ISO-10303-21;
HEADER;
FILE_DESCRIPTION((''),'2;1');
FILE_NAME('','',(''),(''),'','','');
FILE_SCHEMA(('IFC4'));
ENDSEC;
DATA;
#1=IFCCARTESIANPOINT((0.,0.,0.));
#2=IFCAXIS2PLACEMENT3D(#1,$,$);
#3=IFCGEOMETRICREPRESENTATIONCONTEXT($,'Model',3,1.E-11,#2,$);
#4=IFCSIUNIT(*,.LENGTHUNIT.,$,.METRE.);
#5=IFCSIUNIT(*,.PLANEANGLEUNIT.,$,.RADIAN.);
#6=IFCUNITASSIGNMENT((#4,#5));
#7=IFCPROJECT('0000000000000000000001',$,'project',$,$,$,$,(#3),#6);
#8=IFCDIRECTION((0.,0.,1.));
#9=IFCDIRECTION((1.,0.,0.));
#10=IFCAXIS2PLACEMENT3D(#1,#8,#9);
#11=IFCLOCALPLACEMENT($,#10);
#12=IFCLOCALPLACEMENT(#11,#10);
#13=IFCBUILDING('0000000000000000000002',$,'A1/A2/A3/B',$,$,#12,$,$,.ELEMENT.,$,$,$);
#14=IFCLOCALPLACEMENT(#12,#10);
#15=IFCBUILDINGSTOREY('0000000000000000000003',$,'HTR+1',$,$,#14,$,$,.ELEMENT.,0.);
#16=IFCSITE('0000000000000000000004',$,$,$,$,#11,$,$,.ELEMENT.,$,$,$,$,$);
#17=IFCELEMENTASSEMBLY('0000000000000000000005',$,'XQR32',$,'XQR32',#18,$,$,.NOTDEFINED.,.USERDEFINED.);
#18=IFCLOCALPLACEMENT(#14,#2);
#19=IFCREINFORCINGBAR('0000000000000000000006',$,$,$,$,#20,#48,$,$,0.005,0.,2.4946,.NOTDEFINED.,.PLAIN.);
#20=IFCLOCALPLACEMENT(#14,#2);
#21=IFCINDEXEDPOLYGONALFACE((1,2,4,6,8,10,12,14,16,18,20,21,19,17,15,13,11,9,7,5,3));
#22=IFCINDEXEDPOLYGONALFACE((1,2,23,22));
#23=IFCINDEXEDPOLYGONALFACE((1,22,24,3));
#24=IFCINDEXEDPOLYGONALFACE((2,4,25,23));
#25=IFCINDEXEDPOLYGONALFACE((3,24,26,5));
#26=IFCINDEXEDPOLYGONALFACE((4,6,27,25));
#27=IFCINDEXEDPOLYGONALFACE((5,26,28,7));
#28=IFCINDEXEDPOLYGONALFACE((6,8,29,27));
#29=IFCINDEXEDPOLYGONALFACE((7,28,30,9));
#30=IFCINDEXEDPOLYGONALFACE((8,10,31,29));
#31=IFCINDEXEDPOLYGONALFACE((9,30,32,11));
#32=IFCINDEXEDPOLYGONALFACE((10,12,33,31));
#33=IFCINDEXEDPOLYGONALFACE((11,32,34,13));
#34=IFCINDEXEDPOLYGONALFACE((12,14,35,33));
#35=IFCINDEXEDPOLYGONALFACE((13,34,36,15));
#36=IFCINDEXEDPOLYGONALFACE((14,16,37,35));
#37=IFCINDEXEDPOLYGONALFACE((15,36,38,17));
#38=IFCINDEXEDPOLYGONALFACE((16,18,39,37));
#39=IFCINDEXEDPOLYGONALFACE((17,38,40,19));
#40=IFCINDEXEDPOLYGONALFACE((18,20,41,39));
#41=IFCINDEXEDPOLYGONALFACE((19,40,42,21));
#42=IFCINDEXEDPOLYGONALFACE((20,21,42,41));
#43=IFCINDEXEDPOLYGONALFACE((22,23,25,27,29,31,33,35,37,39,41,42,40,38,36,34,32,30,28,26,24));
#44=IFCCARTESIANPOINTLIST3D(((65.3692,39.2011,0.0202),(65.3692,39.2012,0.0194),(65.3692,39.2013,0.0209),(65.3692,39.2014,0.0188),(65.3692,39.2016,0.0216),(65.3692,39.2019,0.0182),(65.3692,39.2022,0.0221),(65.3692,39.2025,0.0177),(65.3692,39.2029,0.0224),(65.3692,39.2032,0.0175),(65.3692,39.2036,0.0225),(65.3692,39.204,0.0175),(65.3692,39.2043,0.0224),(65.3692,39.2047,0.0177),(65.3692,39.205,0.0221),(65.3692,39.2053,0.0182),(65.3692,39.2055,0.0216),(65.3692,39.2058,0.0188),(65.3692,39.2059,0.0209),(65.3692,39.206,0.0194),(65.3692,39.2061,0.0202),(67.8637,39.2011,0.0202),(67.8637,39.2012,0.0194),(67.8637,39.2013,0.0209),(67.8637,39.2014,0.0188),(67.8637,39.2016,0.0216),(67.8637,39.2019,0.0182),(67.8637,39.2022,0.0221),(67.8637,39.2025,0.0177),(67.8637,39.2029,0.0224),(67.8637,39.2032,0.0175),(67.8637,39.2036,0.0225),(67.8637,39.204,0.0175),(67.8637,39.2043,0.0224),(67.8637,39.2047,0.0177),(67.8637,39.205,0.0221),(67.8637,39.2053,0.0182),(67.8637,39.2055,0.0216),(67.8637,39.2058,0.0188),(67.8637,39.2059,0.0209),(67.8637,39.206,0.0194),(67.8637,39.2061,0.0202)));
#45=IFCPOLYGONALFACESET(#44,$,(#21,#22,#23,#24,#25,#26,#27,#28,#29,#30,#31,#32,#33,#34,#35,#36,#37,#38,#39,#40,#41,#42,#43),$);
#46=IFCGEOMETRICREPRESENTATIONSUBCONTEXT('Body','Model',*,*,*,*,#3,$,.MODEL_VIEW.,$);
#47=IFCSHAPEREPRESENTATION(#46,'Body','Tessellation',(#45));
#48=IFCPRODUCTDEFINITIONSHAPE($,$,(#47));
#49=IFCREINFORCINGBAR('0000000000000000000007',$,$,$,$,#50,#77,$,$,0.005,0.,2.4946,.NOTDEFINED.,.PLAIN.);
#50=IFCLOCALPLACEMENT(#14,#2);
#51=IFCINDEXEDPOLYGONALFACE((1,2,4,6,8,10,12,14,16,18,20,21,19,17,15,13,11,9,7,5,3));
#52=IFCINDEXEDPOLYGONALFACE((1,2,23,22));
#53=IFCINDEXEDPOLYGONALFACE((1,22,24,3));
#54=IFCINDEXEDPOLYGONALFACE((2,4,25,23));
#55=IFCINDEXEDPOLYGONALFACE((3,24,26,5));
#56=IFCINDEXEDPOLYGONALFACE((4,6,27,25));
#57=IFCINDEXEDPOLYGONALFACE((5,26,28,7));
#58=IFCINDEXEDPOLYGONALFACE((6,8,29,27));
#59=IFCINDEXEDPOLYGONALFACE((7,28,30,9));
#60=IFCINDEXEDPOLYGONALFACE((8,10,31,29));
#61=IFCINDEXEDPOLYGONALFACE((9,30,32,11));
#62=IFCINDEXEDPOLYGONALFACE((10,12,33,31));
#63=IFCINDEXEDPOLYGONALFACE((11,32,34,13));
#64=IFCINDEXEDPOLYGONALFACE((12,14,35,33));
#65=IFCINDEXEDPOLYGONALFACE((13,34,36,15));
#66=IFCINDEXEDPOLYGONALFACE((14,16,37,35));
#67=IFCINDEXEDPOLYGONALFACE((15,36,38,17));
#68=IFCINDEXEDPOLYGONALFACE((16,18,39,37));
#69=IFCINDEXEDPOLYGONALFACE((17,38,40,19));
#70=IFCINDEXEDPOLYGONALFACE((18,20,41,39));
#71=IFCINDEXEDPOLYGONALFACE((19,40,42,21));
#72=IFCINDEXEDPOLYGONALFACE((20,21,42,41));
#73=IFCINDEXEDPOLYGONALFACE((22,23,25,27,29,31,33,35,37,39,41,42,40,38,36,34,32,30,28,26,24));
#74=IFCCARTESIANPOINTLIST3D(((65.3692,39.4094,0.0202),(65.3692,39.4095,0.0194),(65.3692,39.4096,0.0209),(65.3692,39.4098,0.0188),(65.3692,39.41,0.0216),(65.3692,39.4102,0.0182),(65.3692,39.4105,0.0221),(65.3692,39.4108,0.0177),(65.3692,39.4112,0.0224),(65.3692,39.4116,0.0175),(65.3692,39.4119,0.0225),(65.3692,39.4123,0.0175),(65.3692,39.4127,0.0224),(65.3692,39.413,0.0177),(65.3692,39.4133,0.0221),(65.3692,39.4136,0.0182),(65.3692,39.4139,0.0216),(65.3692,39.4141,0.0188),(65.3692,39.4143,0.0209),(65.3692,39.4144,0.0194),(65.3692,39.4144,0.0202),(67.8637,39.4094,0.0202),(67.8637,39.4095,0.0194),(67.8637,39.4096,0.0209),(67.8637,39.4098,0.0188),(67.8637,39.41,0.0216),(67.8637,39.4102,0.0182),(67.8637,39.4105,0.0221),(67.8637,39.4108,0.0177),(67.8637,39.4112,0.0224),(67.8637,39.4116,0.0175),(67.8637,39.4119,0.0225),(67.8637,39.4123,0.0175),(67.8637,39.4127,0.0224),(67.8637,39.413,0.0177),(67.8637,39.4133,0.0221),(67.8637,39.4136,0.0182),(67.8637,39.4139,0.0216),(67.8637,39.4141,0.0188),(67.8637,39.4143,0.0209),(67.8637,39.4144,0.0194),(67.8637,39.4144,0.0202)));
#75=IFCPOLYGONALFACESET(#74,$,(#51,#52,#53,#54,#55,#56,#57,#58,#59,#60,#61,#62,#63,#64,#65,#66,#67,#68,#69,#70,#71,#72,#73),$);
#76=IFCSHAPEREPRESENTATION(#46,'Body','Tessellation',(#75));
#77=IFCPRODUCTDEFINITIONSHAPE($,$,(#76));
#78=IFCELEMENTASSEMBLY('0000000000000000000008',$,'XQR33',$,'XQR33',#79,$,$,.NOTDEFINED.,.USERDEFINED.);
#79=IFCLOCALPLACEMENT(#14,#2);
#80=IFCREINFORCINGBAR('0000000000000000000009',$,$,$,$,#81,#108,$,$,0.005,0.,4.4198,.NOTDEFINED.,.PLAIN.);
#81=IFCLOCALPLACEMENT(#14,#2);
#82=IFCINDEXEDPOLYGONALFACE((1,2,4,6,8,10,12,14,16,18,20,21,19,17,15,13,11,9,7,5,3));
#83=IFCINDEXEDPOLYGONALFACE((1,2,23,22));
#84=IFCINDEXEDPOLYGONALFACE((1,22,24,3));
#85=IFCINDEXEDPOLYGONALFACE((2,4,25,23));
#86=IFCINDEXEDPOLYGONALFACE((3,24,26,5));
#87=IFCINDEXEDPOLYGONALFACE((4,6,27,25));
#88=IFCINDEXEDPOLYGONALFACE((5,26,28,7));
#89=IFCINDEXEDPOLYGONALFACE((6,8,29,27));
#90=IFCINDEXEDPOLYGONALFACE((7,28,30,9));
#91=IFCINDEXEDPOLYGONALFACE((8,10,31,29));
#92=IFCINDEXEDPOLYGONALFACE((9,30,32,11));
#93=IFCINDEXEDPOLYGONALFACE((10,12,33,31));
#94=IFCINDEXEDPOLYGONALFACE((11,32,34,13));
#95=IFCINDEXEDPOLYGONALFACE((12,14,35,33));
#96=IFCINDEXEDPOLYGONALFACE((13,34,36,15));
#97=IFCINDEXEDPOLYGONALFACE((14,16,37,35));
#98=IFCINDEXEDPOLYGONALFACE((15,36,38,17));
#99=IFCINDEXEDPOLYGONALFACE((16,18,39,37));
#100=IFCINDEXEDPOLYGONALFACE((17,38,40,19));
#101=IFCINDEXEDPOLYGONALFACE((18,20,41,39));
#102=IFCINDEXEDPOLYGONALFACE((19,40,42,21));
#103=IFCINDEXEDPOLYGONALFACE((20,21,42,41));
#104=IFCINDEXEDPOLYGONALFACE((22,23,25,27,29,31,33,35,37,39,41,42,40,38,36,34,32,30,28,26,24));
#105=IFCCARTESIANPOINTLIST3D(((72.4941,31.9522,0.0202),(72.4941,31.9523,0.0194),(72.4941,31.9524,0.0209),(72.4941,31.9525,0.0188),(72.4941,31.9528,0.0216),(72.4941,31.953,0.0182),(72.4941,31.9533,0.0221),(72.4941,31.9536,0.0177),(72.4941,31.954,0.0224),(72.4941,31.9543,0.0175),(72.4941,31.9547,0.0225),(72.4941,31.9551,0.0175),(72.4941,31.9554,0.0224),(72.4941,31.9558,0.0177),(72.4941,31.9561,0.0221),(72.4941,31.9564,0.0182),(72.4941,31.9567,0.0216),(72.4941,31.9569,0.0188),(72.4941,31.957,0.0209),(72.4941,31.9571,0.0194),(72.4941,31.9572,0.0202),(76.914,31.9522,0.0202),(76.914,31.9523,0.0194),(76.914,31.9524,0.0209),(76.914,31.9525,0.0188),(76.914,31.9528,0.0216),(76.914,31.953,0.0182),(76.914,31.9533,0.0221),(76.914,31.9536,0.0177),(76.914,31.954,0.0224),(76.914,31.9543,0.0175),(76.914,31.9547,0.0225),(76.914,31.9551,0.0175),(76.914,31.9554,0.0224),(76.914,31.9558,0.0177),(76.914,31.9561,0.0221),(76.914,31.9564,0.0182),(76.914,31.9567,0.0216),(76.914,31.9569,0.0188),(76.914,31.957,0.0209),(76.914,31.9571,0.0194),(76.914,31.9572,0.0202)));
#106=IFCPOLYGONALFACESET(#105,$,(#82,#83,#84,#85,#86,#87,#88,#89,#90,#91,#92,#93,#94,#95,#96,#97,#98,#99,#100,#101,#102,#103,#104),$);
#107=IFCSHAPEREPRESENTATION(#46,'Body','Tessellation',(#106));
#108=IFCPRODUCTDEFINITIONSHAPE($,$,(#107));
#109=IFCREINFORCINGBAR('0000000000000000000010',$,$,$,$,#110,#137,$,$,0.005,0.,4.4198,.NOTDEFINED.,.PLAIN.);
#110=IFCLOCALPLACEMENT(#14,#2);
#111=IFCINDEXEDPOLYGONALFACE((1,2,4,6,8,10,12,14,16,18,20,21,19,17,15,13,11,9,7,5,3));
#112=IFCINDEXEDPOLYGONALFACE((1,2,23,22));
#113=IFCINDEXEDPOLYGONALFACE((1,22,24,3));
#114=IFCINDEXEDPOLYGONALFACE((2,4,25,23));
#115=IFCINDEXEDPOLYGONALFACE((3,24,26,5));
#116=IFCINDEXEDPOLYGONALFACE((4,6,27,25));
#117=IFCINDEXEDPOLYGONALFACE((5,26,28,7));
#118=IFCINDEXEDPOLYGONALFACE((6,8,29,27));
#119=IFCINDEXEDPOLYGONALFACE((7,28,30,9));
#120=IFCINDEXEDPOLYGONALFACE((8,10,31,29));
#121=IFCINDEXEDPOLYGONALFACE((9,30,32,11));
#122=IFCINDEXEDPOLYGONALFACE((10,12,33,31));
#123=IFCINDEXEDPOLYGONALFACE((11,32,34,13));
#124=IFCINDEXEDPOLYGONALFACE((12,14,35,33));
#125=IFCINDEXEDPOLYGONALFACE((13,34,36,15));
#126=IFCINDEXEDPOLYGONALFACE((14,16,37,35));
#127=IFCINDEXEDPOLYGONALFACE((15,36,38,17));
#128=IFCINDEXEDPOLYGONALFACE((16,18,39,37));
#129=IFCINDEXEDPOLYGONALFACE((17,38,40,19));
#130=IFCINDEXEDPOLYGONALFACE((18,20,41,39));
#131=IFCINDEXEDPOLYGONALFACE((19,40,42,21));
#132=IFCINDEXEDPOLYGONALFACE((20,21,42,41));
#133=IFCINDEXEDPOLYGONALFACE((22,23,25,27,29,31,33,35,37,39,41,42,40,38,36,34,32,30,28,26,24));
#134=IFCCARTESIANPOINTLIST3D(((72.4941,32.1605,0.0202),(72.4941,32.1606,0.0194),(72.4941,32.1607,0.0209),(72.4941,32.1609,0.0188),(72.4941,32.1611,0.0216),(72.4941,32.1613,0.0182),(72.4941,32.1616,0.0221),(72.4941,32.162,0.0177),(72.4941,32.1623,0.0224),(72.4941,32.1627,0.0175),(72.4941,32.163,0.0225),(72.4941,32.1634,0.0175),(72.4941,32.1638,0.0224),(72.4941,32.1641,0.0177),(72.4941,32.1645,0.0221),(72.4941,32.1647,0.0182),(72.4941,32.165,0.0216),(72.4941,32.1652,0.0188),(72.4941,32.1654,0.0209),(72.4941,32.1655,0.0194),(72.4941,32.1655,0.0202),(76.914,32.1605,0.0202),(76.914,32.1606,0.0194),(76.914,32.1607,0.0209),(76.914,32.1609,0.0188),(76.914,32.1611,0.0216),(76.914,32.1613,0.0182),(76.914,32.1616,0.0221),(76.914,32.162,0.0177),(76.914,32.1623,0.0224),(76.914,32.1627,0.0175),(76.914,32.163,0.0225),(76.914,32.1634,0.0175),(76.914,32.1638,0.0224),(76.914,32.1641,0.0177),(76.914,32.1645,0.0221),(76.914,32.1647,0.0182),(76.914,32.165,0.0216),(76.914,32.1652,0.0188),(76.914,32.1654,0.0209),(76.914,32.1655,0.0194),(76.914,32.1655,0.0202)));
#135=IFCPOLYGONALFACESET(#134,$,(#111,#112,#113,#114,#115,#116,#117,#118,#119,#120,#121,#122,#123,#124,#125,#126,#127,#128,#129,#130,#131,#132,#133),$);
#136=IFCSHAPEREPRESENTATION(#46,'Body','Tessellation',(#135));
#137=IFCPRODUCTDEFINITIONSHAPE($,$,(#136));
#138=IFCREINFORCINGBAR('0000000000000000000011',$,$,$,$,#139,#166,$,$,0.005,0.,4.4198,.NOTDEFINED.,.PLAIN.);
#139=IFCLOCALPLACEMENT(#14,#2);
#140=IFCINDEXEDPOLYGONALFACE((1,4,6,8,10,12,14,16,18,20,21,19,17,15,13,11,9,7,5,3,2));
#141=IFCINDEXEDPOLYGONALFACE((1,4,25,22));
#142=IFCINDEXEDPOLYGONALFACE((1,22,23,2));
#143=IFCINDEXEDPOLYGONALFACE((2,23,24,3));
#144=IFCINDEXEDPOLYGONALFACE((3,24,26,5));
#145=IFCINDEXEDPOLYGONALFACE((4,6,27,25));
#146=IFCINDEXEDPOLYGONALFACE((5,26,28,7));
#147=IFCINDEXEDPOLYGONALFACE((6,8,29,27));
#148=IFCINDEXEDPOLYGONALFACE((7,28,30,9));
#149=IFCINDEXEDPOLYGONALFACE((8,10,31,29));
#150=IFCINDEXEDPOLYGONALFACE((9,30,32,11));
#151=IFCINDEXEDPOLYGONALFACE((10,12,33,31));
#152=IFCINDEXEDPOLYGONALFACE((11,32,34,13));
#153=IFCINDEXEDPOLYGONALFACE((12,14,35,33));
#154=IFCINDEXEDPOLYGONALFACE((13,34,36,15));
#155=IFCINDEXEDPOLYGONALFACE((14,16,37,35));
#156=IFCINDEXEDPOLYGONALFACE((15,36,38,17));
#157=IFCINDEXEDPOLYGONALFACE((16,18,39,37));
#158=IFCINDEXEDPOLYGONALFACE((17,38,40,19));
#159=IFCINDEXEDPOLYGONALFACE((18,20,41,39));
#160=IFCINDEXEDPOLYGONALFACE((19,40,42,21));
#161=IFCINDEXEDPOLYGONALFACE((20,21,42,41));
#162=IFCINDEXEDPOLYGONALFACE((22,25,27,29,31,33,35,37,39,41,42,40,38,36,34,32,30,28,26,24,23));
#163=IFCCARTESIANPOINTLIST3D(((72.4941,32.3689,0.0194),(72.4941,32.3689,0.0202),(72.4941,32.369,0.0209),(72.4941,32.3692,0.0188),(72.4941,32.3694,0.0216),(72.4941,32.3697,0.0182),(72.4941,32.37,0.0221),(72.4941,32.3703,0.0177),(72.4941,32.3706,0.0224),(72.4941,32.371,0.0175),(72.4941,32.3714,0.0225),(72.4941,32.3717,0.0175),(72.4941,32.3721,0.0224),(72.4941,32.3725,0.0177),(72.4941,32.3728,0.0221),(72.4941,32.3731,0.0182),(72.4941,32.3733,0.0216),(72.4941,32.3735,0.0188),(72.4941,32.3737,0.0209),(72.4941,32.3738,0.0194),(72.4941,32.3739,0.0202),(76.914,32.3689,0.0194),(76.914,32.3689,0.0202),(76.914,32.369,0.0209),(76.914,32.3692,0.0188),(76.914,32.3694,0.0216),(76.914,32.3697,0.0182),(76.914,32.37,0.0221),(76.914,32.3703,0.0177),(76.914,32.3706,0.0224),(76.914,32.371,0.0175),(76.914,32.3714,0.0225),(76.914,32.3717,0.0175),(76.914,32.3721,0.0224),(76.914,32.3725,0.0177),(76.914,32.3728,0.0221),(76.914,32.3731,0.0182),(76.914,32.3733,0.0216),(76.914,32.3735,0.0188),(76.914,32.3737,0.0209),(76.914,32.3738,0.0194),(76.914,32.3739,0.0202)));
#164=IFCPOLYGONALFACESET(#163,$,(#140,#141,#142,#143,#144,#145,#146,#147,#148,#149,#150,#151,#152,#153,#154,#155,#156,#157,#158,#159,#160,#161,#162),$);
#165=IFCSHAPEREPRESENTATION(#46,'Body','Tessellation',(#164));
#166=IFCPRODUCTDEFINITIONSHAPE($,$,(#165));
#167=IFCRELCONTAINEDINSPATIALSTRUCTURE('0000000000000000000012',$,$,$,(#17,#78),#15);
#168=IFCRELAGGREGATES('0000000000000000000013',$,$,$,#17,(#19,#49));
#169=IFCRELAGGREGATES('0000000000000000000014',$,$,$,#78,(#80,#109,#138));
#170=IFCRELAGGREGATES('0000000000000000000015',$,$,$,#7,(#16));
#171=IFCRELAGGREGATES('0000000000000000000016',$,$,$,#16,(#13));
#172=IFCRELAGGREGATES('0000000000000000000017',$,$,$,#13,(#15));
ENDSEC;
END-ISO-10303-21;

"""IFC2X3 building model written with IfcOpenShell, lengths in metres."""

from ifc_helpers import new_model, entity, si_unit, origin, origin_with_axes, place, context, subcontext, project, spatial, shape, element, aggregate, save


model = new_model("IFC2X3")

# Units and contexts
model_context = context("Model", 3, precision=1e-11, world=origin())
body_context = subcontext(model_context, "Body", "Model", "MODEL_VIEW")
ifc_project = project(units=[si_unit("LENGTHUNIT", "METRE"), si_unit("PLANEANGLEUNIT", "RADIAN")], contexts=[model_context])

# Site, building, storey
site_placement = place(None, origin_with_axes())
site = spatial("IfcSite", under=ifc_project, at=site_placement, CompositionType="ELEMENT")
building_placement = place(site_placement, origin_with_axes())
building = spatial("IfcBuilding", under=site, at=building_placement, Name="A1/A2/A3/B", CompositionType="ELEMENT")
storey_placement = place(building_placement, origin_with_axes())
storey = spatial("IfcBuildingStorey", under=building, at=storey_placement, Name="HTR+1", CompositionType="ELEMENT", Elevation=0.0)

# Element assemblies, reinforcing bars
assembly_1_placement = place(storey_placement, origin_with_axes())
assembly_1 = element("IfcElementAssembly", 1, at=assembly_1_placement, inside=storey, Name="XQR32", ObjectType="XQR32", AssemblyPlace="NOTDEFINED", PredefinedType="USERDEFINED")
reinforcing_bar_1_placement = place(assembly_1_placement, origin_with_axes())
reinforcing_bar_1 = element("IfcReinforcingBar", 2, at=reinforcing_bar_1_placement, BarLength=2.4946, BarRole="NOTDEFINED", BarSurface="PLAIN", CrossSectionArea=0.0, NominalDiameter=0.005, shapes=[
    shape(body_context, "Body", "AdvancedSweptSolid", [entity("IfcSweptDiskSolid", entity("IfcPolyline", [entity("IfcCartesianPoint", [65.3692, 39.2036, 0.02]), entity("IfcCartesianPoint", [67.8637, 39.2036, 0.02])]), 0.0025, None, 0.0, 2.4946)]),
    shape(body_context, "Body", "AdvancedSweptSolid", [entity("IfcSweptDiskSolid", entity("IfcPolyline", [entity("IfcCartesianPoint", [65.3692, 39.2036, 0.02]), entity("IfcCartesianPoint", [67.8637, 39.2036, 0.02])]), 0.0025, None, 0.0, 2.4946)]),
])
reinforcing_bar_2_placement = place(assembly_1_placement, origin_with_axes())
reinforcing_bar_2 = element("IfcReinforcingBar", 3, at=reinforcing_bar_2_placement, BarLength=2.4946, BarRole="NOTDEFINED", BarSurface="PLAIN", CrossSectionArea=0.0, NominalDiameter=0.005, shapes=[
    shape(body_context, "Body", "AdvancedSweptSolid", [entity("IfcSweptDiskSolid", entity("IfcPolyline", [entity("IfcCartesianPoint", [65.3692, 39.4119, 0.02]), entity("IfcCartesianPoint", [67.8637, 39.4119, 0.02])]), 0.0025, None, 0.0, 2.4946)]),
    shape(body_context, "Body", "AdvancedSweptSolid", [entity("IfcSweptDiskSolid", entity("IfcPolyline", [entity("IfcCartesianPoint", [65.3692, 39.4119, 0.02]), entity("IfcCartesianPoint", [67.8637, 39.4119, 0.02])]), 0.0025, None, 0.0, 2.4946)]),
])
aggregate(assembly_1, [reinforcing_bar_1, reinforcing_bar_2])
assembly_2_placement = place(storey_placement, origin_with_axes())
assembly_2 = element("IfcElementAssembly", 4, at=assembly_2_placement, inside=storey, Name="XQR33", ObjectType="XQR33", AssemblyPlace="NOTDEFINED", PredefinedType="USERDEFINED")
reinforcing_bar_3_placement = place(assembly_2_placement, origin_with_axes())
reinforcing_bar_3 = element("IfcReinforcingBar", 5, at=reinforcing_bar_3_placement, BarLength=4.4198, BarRole="NOTDEFINED", BarSurface="PLAIN", CrossSectionArea=0.0, NominalDiameter=0.005, shapes=[
    shape(body_context, "Body", "AdvancedSweptSolid", [entity("IfcSweptDiskSolid", entity("IfcPolyline", [entity("IfcCartesianPoint", [72.4941, 31.9547, 0.02]), entity("IfcCartesianPoint", [76.914, 31.9547, 0.02])]), 0.0025, None, 0.0, 4.4198)]),
    shape(body_context, "Body", "AdvancedSweptSolid", [entity("IfcSweptDiskSolid", entity("IfcPolyline", [entity("IfcCartesianPoint", [72.4941, 31.9547, 0.02]), entity("IfcCartesianPoint", [76.914, 31.9547, 0.02])]), 0.0025, None, 0.0, 4.4198)]),
])
reinforcing_bar_4_placement = place(assembly_2_placement, origin_with_axes())
reinforcing_bar_4 = element("IfcReinforcingBar", 6, at=reinforcing_bar_4_placement, BarLength=4.4198, BarRole="NOTDEFINED", BarSurface="PLAIN", CrossSectionArea=0.0, NominalDiameter=0.005, shapes=[
    shape(body_context, "Body", "AdvancedSweptSolid", [entity("IfcSweptDiskSolid", entity("IfcPolyline", [entity("IfcCartesianPoint", [72.4941, 32.163, 0.02]), entity("IfcCartesianPoint", [76.914, 32.163, 0.02])]), 0.0025, None, 0.0, 4.4198)]),
    shape(body_context, "Body", "AdvancedSweptSolid", [entity("IfcSweptDiskSolid", entity("IfcPolyline", [entity("IfcCartesianPoint", [72.4941, 32.163, 0.02]), entity("IfcCartesianPoint", [76.914, 32.163, 0.02])]), 0.0025, None, 0.0, 4.4198)]),
])
reinforcing_bar_5_placement = place(assembly_2_placement, origin_with_axes())
reinforcing_bar_5 = element("IfcReinforcingBar", 7, at=reinforcing_bar_5_placement, BarLength=4.4198, BarRole="NOTDEFINED", BarSurface="PLAIN", CrossSectionArea=0.0, NominalDiameter=0.005, shapes=[
    shape(body_context, "Body", "AdvancedSweptSolid", [entity("IfcSweptDiskSolid", entity("IfcPolyline", [entity("IfcCartesianPoint", [72.4941, 32.3714, 0.02]), entity("IfcCartesianPoint", [76.914, 32.3714, 0.02])]), 0.0025, None, 0.0, 4.4198)]),
    shape(body_context, "Body", "AdvancedSweptSolid", [entity("IfcSweptDiskSolid", entity("IfcPolyline", [entity("IfcCartesianPoint", [72.4941, 32.3714, 0.02]), entity("IfcCartesianPoint", [76.914, 32.3714, 0.02])]), 0.0025, None, 0.0, 4.4198)]),
])
aggregate(assembly_2, [reinforcing_bar_3, reinforcing_bar_4, reinforcing_bar_5])

save(model, "model.ifc")
